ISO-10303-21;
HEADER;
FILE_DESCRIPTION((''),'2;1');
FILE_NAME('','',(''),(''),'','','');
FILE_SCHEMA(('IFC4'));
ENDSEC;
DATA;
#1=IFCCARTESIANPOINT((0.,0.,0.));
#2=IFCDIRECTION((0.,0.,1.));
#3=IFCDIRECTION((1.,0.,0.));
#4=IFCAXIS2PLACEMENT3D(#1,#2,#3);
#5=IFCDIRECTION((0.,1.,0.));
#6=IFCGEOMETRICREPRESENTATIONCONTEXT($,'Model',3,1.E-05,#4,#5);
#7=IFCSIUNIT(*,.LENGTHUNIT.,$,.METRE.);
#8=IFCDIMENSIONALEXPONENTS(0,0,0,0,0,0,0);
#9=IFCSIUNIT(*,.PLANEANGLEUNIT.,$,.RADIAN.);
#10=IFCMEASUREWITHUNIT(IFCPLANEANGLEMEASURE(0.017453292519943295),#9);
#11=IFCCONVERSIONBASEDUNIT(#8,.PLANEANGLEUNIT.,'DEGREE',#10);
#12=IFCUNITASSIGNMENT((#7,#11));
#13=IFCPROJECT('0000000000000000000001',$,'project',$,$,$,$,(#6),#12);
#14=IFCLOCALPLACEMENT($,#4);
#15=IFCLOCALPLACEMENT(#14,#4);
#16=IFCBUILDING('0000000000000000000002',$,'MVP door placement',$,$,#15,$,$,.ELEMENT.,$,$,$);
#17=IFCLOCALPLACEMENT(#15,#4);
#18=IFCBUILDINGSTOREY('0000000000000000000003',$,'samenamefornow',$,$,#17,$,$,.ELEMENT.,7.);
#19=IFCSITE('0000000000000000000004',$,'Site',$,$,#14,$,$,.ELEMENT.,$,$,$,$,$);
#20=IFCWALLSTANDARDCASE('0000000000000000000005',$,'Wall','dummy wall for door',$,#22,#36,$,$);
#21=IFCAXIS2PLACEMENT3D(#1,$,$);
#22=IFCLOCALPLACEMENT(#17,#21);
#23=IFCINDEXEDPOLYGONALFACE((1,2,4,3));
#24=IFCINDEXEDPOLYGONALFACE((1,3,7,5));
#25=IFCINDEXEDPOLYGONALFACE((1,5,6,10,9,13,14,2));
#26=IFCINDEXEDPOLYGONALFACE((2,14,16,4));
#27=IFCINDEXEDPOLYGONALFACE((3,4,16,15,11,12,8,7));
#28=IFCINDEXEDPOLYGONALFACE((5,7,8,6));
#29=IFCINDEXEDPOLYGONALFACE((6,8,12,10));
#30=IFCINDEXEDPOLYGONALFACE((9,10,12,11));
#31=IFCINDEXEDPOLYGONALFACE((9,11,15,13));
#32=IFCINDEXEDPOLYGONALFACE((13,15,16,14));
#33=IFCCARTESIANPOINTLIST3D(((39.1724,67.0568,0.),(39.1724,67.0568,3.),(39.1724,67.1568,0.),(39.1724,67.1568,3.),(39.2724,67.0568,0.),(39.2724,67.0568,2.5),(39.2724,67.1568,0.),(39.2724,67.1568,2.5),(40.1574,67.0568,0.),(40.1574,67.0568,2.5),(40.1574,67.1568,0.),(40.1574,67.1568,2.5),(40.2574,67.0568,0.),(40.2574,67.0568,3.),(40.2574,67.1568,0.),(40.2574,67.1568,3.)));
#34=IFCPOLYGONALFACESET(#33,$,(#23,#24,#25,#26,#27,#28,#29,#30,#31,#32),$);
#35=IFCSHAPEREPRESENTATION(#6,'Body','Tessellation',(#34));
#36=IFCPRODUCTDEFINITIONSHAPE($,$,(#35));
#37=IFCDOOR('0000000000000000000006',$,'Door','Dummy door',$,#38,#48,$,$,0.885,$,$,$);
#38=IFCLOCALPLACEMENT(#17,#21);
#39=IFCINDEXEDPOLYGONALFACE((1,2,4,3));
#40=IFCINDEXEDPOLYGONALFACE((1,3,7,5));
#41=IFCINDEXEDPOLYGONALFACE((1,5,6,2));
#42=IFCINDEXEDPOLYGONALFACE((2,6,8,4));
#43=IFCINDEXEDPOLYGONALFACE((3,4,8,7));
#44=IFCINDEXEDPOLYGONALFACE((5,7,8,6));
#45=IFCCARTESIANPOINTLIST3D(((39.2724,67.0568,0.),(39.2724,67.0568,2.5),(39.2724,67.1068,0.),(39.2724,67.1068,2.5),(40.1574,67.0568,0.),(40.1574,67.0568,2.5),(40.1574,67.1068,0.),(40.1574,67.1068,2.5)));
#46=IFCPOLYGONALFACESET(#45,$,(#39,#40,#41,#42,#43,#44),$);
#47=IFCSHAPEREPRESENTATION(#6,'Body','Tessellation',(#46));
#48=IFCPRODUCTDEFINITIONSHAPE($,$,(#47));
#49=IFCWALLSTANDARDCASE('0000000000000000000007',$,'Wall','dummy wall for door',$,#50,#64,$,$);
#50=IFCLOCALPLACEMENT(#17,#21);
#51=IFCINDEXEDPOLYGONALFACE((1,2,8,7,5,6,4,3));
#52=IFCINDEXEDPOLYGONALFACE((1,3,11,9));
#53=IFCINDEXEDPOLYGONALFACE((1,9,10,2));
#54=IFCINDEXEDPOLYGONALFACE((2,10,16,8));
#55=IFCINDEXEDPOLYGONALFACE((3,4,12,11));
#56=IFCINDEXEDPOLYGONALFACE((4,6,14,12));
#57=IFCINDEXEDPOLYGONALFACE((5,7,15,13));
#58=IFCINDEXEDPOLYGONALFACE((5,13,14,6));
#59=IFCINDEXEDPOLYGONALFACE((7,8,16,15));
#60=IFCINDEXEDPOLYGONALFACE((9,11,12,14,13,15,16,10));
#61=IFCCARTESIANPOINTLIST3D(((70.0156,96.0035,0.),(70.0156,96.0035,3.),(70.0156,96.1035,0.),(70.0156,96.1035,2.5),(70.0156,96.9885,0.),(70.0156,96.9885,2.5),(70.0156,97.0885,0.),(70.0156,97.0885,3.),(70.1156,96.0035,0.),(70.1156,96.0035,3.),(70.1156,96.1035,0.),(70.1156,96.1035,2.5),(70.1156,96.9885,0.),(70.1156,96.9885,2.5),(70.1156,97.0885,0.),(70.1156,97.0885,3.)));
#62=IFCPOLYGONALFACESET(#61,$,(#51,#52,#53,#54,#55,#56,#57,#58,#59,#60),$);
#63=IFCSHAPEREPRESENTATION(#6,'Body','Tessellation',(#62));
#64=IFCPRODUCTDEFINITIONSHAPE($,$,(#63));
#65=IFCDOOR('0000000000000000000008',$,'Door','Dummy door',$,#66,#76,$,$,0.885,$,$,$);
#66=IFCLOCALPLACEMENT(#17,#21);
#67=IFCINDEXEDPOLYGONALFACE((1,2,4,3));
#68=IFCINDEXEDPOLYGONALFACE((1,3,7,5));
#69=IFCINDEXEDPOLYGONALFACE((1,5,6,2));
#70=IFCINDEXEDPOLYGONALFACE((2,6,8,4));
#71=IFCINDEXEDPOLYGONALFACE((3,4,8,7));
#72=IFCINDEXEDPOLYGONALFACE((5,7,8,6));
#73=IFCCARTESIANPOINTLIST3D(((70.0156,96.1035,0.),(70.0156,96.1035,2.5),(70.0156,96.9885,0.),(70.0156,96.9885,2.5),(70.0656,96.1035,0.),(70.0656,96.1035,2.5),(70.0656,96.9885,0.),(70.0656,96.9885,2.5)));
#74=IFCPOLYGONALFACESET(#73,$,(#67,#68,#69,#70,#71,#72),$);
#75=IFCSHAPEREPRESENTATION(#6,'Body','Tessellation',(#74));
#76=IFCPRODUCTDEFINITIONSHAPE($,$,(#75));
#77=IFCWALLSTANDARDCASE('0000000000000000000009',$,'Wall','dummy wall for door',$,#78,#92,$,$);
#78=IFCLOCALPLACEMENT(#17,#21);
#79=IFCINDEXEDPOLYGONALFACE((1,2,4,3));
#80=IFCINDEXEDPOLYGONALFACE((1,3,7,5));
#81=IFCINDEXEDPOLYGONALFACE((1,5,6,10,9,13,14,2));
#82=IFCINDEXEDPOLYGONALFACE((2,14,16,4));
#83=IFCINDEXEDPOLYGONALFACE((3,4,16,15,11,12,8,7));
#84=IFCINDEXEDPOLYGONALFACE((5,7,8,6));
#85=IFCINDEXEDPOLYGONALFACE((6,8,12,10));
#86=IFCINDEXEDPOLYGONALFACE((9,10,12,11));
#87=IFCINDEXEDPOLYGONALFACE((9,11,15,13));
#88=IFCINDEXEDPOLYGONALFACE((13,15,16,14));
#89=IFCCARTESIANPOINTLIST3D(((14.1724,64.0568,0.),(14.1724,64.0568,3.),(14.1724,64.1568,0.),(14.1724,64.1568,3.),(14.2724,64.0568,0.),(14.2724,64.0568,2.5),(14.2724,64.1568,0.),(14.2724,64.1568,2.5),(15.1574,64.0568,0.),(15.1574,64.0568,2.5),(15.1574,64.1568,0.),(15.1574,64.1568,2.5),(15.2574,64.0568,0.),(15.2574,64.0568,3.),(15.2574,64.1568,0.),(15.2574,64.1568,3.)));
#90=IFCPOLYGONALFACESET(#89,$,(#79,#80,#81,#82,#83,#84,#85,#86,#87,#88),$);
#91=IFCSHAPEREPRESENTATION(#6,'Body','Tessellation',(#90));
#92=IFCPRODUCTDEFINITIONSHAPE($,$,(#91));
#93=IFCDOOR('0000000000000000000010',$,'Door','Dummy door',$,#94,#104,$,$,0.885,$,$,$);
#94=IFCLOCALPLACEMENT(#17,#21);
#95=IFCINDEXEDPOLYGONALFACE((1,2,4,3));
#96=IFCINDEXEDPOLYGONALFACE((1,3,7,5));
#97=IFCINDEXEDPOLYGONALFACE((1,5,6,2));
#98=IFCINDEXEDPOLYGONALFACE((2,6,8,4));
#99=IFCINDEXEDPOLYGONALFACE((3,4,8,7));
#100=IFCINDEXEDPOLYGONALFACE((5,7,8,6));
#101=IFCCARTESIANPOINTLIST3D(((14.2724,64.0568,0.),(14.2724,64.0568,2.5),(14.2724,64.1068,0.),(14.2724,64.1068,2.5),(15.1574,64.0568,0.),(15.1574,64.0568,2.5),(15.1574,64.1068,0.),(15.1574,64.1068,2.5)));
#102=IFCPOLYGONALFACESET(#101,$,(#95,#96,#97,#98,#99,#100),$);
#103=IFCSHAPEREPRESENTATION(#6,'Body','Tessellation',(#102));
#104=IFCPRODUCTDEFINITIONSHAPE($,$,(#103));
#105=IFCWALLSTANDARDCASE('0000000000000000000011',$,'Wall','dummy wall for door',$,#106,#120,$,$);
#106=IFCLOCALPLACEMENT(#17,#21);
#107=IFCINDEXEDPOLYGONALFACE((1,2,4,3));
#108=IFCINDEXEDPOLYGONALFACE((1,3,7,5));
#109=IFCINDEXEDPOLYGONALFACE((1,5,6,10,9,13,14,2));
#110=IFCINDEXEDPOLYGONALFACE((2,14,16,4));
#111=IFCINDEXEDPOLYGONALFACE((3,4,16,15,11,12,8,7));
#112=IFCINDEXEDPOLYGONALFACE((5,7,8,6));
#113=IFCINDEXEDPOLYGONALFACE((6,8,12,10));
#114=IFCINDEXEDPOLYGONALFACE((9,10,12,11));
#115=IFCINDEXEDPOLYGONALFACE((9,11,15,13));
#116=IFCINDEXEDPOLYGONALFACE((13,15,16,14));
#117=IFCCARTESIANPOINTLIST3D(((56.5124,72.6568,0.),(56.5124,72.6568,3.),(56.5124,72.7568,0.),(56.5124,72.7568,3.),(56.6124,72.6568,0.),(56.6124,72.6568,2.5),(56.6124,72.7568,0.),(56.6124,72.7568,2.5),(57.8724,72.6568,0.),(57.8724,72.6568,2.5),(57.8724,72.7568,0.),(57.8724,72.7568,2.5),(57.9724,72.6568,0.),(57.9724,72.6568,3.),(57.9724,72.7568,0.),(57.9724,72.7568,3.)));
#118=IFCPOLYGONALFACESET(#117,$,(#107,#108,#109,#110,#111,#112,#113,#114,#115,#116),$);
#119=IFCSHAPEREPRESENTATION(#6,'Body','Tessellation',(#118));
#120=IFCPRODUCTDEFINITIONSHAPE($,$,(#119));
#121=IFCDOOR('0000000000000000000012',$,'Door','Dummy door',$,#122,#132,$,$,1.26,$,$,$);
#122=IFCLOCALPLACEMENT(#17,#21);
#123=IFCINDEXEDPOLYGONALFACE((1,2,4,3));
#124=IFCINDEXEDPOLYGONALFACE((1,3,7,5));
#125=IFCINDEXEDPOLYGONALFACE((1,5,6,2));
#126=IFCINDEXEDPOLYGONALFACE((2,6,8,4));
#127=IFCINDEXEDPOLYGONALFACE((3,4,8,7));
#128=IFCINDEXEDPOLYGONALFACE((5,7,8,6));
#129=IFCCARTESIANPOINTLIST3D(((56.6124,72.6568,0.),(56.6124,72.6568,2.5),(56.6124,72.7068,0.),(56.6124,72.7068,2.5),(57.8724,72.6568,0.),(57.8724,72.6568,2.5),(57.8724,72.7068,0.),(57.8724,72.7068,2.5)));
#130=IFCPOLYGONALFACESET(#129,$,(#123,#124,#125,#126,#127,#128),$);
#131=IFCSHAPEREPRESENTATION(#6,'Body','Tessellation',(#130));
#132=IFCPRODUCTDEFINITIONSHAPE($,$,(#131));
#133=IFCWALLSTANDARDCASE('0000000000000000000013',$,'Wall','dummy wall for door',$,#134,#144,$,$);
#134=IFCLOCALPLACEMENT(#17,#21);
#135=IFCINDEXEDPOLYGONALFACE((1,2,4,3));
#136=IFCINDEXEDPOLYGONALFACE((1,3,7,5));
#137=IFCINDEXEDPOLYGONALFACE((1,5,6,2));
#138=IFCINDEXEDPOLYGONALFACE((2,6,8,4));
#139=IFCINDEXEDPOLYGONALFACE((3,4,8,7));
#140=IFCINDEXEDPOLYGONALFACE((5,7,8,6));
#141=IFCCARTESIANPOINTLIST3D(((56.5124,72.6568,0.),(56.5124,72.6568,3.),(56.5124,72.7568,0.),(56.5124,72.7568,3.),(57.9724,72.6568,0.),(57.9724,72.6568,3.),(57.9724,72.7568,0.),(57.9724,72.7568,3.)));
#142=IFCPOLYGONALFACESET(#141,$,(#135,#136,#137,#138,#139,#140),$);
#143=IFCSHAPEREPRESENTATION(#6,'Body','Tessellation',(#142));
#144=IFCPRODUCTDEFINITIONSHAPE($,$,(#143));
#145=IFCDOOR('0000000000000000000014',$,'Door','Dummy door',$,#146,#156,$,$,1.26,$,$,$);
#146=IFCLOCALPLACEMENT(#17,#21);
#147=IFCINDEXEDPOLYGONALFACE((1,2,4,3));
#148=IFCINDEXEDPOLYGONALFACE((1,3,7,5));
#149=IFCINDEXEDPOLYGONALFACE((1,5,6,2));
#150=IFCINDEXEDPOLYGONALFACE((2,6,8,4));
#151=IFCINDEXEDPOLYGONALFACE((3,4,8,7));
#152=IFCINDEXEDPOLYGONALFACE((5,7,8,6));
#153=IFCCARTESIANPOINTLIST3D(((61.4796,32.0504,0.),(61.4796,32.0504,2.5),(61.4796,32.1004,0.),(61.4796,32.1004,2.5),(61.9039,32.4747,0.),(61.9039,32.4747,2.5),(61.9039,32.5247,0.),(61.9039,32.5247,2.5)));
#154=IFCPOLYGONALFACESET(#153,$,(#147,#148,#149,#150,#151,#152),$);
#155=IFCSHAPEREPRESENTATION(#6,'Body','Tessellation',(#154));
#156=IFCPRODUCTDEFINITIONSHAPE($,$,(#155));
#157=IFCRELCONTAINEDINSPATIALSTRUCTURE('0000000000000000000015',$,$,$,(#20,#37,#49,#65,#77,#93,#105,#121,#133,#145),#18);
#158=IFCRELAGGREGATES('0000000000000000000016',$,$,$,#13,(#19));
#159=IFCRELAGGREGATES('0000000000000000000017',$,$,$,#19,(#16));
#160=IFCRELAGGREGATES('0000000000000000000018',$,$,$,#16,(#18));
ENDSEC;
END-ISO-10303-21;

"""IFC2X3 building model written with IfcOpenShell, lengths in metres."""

from ifc_helpers import new_model, entity, si_unit, converted_unit, direction, origin_with_axes, place, context, project, spatial, polyline, outline, extrude, element, fill, save


model = new_model("IFC2X3")

# Units and contexts
model_context = context("Model", 3, precision=1e-05, world=origin_with_axes(), true_north=direction((0.0, 1.0, 0.0)))
ifc_project = project(units=[si_unit("LENGTHUNIT", "METRE"), converted_unit("PLANEANGLEUNIT", "DEGREE", entity("IfcPlaneAngleMeasure", 0.017453292519943295), si_unit("PLANEANGLEUNIT", "RADIAN"), dimensions=[0, 0, 0, 0, 0, 0, 0])], contexts=[model_context])

# Site, building, storey
site_placement = place(None, origin_with_axes())
site = spatial("IfcSite", under=ifc_project, at=site_placement, Name="Site", CompositionType="ELEMENT")
building_placement = place(site_placement, origin_with_axes())
building = spatial("IfcBuilding", under=site, at=building_placement, Name="MVP door placement", CompositionType="ELEMENT")
storey_placement = place(building_placement, origin_with_axes())
storey = spatial("IfcBuildingStorey", under=building, at=storey_placement, Name="samenamefornow", CompositionType="ELEMENT", Elevation=7.0)

# Walls, openings, doors
wall_1_placement = place(storey_placement, origin_with_axes())
wall_1 = element("IfcWallStandardCase", 1, at=wall_1_placement, inside=storey, Name="Wall", Description="dummy wall for door", context=model_context, shape_type="SweptSolid", body=[
    extrude(outline(polyline([(40.2574, 67.0568, 0.0), (39.1724, 67.0568, 0.0), (39.1724, 67.1568, 0.0), (40.2574, 67.1568, 0.0), (40.2574, 67.0568, 0.0)])), origin_with_axes(), (0.0, 0.0, 1.0), 3.0),
])
opening_1_placement = place(wall_1_placement, origin_with_axes())
opening_1 = element("IfcOpeningElement", 2, at=opening_1_placement, cuts=wall_1, context=model_context, shape_type="SweptSolid", body=[
    extrude(outline(polyline([(40.1574, 67.0568, 0.0), (39.2724, 67.0568, 0.0), (39.2724, 67.1568, 0.0), (40.1574, 67.1568, 0.0), (40.1574, 67.0568, 0.0)])), origin_with_axes(), (0.0, 0.0, 1.0), 2.5),
])
door_1_placement = place(opening_1_placement, origin_with_axes())
door_1 = element("IfcDoor", 3, at=door_1_placement, inside=storey, Name="Door", Description="Dummy door", OverallWidth=0.885, context=model_context, shape_type="SweptSolid", body=[
    extrude(outline(polyline([(40.1574, 67.0568, 0.0), (39.2724, 67.0568, 0.0), (39.2724, 67.1068, 0.0), (40.1574, 67.1068, 0.0), (40.1574, 67.0568, 0.0)])), origin_with_axes(), (0.0, 0.0, 1.0), 2.5),
])
fill(opening_1, door_1)
wall_2_placement = place(storey_placement, origin_with_axes())
wall_2 = element("IfcWallStandardCase", 4, at=wall_2_placement, inside=storey, Name="Wall", Description="dummy wall for door", context=model_context, shape_type="SweptSolid", body=[
    extrude(outline(polyline([(70.0156, 96.0035, 0.0), (70.0156, 97.0885, 0.0), (70.1156, 97.0885, 0.0), (70.1156, 96.0035, 0.0), (70.0156, 96.0035, 0.0)])), origin_with_axes(), (0.0, 0.0, 1.0), 3.0),
])
opening_2_placement = place(wall_2_placement, origin_with_axes())
opening_2 = element("IfcOpeningElement", 5, at=opening_2_placement, cuts=wall_2, context=model_context, shape_type="SweptSolid", body=[
    extrude(outline(polyline([(70.0156, 96.1035, 0.0), (70.0156, 96.9885, 0.0), (70.1156, 96.9885, 0.0), (70.1156, 96.1035, 0.0), (70.0156, 96.1035, 0.0)])), origin_with_axes(), (0.0, 0.0, 1.0), 2.5),
])
door_2_placement = place(opening_2_placement, origin_with_axes())
door_2 = element("IfcDoor", 6, at=door_2_placement, inside=storey, Name="Door", Description="Dummy door", OverallWidth=0.885, context=model_context, shape_type="SweptSolid", body=[
    extrude(outline(polyline([(70.0156, 96.1035, 0.0), (70.0156, 96.9885, 0.0), (70.0656, 96.9885, 0.0), (70.0656, 96.1035, 0.0), (70.0156, 96.1035, 0.0)])), origin_with_axes(), (0.0, 0.0, 1.0), 2.5),
])
fill(opening_2, door_2)
wall_3_placement = place(storey_placement, origin_with_axes())
wall_3 = element("IfcWallStandardCase", 7, at=wall_3_placement, inside=storey, Name="Wall", Description="dummy wall for door", context=model_context, shape_type="SweptSolid", body=[
    extrude(outline(polyline([(15.2574, 64.0568, 0.0), (14.1724, 64.0568, 0.0), (14.1724, 64.1568, 0.0), (15.2574, 64.1568, 0.0), (15.2574, 64.0568, 0.0)])), origin_with_axes(), (0.0, 0.0, 1.0), 3.0),
])
opening_3_placement = place(wall_3_placement, origin_with_axes())
opening_3 = element("IfcOpeningElement", 8, at=opening_3_placement, cuts=wall_3, context=model_context, shape_type="SweptSolid", body=[
    extrude(outline(polyline([(15.1574, 64.0568, 0.0), (14.2724, 64.0568, 0.0), (14.2724, 64.1568, 0.0), (15.1574, 64.1568, 0.0), (15.1574, 64.0568, 0.0)])), origin_with_axes(), (0.0, 0.0, 1.0), 2.5),
])
door_3_placement = place(opening_3_placement, origin_with_axes())
door_3 = element("IfcDoor", 9, at=door_3_placement, inside=storey, Name="Door", Description="Dummy door", OverallWidth=0.885, context=model_context, shape_type="SweptSolid", body=[
    extrude(outline(polyline([(15.1574, 64.0568, 0.0), (14.2724, 64.0568, 0.0), (14.2724, 64.1068, 0.0), (15.1574, 64.1068, 0.0), (15.1574, 64.0568, 0.0)])), origin_with_axes(), (0.0, 0.0, 1.0), 2.5),
])
fill(opening_3, door_3)
wall_4_placement = place(storey_placement, origin_with_axes())
wall_4 = element("IfcWallStandardCase", 10, at=wall_4_placement, inside=storey, Name="Wall", Description="dummy wall for door", context=model_context, shape_type="SweptSolid", body=[
    extrude(outline(polyline([(57.9724, 72.6568, 0.0), (56.5124, 72.6568, 0.0), (56.5124, 72.7568, 0.0), (57.9724, 72.7568, 0.0), (57.9724, 72.6568, 0.0)])), origin_with_axes(), (0.0, 0.0, 1.0), 3.0),
])
opening_4_placement = place(wall_4_placement, origin_with_axes())
opening_4 = element("IfcOpeningElement", 11, at=opening_4_placement, cuts=wall_4, context=model_context, shape_type="SweptSolid", body=[
    extrude(outline(polyline([(57.8724, 72.6568, 0.0), (56.6124, 72.6568, 0.0), (56.6124, 72.7568, 0.0), (57.8724, 72.7568, 0.0), (57.8724, 72.6568, 0.0)])), origin_with_axes(), (0.0, 0.0, 1.0), 2.5),
])
door_4_placement = place(opening_4_placement, origin_with_axes())
door_4 = element("IfcDoor", 12, at=door_4_placement, inside=storey, Name="Door", Description="Dummy door", OverallWidth=1.26, context=model_context, shape_type="SweptSolid", body=[
    extrude(outline(polyline([(57.8724, 72.6568, 0.0), (56.6124, 72.6568, 0.0), (56.6124, 72.7068, 0.0), (57.8724, 72.7068, 0.0), (57.8724, 72.6568, 0.0)])), origin_with_axes(), (0.0, 0.0, 1.0), 2.5),
])
fill(opening_4, door_4)
wall_5_placement = place(storey_placement, origin_with_axes())
wall_5 = element("IfcWallStandardCase", 13, at=wall_5_placement, inside=storey, Name="Wall", Description="dummy wall for door", context=model_context, shape_type="SweptSolid", body=[
    extrude(outline(polyline([(57.9724, 72.6568, 0.0), (56.5124, 72.6568, 0.0), (56.5124, 72.7568, 0.0), (57.9724, 72.7568, 0.0), (57.9724, 72.6568, 0.0)])), origin_with_axes(), (0.0, 0.0, 1.0), 3.0),
])
opening_5_placement = place(wall_5_placement, origin_with_axes())
opening_5 = element("IfcOpeningElement", 14, at=opening_5_placement, cuts=wall_5, context=model_context, shape_type="SweptSolid", body=[
    extrude(outline(polyline([(61.4796, 32.0504, 0.0), (61.9039, 32.4747, 0.0), (61.9039, 32.5747, 0.0), (61.4796, 32.1504, 0.0), (61.4796, 32.0504, 0.0)])), origin_with_axes(), (0.0, 0.0, 1.0), 2.5),
])
door_5_placement = place(opening_5_placement, origin_with_axes())
door_5 = element("IfcDoor", 15, at=door_5_placement, inside=storey, Name="Door", Description="Dummy door", OverallWidth=1.26, context=model_context, shape_type="SweptSolid", body=[
    extrude(outline(polyline([(61.4796, 32.0504, 0.0), (61.9039, 32.4747, 0.0), (61.9039, 32.5247, 0.0), (61.4796, 32.1004, 0.0), (61.4796, 32.0504, 0.0)])), origin_with_axes(), (0.0, 0.0, 1.0), 2.5),
])
fill(opening_5, door_5)

save(model, "model.ifc")
